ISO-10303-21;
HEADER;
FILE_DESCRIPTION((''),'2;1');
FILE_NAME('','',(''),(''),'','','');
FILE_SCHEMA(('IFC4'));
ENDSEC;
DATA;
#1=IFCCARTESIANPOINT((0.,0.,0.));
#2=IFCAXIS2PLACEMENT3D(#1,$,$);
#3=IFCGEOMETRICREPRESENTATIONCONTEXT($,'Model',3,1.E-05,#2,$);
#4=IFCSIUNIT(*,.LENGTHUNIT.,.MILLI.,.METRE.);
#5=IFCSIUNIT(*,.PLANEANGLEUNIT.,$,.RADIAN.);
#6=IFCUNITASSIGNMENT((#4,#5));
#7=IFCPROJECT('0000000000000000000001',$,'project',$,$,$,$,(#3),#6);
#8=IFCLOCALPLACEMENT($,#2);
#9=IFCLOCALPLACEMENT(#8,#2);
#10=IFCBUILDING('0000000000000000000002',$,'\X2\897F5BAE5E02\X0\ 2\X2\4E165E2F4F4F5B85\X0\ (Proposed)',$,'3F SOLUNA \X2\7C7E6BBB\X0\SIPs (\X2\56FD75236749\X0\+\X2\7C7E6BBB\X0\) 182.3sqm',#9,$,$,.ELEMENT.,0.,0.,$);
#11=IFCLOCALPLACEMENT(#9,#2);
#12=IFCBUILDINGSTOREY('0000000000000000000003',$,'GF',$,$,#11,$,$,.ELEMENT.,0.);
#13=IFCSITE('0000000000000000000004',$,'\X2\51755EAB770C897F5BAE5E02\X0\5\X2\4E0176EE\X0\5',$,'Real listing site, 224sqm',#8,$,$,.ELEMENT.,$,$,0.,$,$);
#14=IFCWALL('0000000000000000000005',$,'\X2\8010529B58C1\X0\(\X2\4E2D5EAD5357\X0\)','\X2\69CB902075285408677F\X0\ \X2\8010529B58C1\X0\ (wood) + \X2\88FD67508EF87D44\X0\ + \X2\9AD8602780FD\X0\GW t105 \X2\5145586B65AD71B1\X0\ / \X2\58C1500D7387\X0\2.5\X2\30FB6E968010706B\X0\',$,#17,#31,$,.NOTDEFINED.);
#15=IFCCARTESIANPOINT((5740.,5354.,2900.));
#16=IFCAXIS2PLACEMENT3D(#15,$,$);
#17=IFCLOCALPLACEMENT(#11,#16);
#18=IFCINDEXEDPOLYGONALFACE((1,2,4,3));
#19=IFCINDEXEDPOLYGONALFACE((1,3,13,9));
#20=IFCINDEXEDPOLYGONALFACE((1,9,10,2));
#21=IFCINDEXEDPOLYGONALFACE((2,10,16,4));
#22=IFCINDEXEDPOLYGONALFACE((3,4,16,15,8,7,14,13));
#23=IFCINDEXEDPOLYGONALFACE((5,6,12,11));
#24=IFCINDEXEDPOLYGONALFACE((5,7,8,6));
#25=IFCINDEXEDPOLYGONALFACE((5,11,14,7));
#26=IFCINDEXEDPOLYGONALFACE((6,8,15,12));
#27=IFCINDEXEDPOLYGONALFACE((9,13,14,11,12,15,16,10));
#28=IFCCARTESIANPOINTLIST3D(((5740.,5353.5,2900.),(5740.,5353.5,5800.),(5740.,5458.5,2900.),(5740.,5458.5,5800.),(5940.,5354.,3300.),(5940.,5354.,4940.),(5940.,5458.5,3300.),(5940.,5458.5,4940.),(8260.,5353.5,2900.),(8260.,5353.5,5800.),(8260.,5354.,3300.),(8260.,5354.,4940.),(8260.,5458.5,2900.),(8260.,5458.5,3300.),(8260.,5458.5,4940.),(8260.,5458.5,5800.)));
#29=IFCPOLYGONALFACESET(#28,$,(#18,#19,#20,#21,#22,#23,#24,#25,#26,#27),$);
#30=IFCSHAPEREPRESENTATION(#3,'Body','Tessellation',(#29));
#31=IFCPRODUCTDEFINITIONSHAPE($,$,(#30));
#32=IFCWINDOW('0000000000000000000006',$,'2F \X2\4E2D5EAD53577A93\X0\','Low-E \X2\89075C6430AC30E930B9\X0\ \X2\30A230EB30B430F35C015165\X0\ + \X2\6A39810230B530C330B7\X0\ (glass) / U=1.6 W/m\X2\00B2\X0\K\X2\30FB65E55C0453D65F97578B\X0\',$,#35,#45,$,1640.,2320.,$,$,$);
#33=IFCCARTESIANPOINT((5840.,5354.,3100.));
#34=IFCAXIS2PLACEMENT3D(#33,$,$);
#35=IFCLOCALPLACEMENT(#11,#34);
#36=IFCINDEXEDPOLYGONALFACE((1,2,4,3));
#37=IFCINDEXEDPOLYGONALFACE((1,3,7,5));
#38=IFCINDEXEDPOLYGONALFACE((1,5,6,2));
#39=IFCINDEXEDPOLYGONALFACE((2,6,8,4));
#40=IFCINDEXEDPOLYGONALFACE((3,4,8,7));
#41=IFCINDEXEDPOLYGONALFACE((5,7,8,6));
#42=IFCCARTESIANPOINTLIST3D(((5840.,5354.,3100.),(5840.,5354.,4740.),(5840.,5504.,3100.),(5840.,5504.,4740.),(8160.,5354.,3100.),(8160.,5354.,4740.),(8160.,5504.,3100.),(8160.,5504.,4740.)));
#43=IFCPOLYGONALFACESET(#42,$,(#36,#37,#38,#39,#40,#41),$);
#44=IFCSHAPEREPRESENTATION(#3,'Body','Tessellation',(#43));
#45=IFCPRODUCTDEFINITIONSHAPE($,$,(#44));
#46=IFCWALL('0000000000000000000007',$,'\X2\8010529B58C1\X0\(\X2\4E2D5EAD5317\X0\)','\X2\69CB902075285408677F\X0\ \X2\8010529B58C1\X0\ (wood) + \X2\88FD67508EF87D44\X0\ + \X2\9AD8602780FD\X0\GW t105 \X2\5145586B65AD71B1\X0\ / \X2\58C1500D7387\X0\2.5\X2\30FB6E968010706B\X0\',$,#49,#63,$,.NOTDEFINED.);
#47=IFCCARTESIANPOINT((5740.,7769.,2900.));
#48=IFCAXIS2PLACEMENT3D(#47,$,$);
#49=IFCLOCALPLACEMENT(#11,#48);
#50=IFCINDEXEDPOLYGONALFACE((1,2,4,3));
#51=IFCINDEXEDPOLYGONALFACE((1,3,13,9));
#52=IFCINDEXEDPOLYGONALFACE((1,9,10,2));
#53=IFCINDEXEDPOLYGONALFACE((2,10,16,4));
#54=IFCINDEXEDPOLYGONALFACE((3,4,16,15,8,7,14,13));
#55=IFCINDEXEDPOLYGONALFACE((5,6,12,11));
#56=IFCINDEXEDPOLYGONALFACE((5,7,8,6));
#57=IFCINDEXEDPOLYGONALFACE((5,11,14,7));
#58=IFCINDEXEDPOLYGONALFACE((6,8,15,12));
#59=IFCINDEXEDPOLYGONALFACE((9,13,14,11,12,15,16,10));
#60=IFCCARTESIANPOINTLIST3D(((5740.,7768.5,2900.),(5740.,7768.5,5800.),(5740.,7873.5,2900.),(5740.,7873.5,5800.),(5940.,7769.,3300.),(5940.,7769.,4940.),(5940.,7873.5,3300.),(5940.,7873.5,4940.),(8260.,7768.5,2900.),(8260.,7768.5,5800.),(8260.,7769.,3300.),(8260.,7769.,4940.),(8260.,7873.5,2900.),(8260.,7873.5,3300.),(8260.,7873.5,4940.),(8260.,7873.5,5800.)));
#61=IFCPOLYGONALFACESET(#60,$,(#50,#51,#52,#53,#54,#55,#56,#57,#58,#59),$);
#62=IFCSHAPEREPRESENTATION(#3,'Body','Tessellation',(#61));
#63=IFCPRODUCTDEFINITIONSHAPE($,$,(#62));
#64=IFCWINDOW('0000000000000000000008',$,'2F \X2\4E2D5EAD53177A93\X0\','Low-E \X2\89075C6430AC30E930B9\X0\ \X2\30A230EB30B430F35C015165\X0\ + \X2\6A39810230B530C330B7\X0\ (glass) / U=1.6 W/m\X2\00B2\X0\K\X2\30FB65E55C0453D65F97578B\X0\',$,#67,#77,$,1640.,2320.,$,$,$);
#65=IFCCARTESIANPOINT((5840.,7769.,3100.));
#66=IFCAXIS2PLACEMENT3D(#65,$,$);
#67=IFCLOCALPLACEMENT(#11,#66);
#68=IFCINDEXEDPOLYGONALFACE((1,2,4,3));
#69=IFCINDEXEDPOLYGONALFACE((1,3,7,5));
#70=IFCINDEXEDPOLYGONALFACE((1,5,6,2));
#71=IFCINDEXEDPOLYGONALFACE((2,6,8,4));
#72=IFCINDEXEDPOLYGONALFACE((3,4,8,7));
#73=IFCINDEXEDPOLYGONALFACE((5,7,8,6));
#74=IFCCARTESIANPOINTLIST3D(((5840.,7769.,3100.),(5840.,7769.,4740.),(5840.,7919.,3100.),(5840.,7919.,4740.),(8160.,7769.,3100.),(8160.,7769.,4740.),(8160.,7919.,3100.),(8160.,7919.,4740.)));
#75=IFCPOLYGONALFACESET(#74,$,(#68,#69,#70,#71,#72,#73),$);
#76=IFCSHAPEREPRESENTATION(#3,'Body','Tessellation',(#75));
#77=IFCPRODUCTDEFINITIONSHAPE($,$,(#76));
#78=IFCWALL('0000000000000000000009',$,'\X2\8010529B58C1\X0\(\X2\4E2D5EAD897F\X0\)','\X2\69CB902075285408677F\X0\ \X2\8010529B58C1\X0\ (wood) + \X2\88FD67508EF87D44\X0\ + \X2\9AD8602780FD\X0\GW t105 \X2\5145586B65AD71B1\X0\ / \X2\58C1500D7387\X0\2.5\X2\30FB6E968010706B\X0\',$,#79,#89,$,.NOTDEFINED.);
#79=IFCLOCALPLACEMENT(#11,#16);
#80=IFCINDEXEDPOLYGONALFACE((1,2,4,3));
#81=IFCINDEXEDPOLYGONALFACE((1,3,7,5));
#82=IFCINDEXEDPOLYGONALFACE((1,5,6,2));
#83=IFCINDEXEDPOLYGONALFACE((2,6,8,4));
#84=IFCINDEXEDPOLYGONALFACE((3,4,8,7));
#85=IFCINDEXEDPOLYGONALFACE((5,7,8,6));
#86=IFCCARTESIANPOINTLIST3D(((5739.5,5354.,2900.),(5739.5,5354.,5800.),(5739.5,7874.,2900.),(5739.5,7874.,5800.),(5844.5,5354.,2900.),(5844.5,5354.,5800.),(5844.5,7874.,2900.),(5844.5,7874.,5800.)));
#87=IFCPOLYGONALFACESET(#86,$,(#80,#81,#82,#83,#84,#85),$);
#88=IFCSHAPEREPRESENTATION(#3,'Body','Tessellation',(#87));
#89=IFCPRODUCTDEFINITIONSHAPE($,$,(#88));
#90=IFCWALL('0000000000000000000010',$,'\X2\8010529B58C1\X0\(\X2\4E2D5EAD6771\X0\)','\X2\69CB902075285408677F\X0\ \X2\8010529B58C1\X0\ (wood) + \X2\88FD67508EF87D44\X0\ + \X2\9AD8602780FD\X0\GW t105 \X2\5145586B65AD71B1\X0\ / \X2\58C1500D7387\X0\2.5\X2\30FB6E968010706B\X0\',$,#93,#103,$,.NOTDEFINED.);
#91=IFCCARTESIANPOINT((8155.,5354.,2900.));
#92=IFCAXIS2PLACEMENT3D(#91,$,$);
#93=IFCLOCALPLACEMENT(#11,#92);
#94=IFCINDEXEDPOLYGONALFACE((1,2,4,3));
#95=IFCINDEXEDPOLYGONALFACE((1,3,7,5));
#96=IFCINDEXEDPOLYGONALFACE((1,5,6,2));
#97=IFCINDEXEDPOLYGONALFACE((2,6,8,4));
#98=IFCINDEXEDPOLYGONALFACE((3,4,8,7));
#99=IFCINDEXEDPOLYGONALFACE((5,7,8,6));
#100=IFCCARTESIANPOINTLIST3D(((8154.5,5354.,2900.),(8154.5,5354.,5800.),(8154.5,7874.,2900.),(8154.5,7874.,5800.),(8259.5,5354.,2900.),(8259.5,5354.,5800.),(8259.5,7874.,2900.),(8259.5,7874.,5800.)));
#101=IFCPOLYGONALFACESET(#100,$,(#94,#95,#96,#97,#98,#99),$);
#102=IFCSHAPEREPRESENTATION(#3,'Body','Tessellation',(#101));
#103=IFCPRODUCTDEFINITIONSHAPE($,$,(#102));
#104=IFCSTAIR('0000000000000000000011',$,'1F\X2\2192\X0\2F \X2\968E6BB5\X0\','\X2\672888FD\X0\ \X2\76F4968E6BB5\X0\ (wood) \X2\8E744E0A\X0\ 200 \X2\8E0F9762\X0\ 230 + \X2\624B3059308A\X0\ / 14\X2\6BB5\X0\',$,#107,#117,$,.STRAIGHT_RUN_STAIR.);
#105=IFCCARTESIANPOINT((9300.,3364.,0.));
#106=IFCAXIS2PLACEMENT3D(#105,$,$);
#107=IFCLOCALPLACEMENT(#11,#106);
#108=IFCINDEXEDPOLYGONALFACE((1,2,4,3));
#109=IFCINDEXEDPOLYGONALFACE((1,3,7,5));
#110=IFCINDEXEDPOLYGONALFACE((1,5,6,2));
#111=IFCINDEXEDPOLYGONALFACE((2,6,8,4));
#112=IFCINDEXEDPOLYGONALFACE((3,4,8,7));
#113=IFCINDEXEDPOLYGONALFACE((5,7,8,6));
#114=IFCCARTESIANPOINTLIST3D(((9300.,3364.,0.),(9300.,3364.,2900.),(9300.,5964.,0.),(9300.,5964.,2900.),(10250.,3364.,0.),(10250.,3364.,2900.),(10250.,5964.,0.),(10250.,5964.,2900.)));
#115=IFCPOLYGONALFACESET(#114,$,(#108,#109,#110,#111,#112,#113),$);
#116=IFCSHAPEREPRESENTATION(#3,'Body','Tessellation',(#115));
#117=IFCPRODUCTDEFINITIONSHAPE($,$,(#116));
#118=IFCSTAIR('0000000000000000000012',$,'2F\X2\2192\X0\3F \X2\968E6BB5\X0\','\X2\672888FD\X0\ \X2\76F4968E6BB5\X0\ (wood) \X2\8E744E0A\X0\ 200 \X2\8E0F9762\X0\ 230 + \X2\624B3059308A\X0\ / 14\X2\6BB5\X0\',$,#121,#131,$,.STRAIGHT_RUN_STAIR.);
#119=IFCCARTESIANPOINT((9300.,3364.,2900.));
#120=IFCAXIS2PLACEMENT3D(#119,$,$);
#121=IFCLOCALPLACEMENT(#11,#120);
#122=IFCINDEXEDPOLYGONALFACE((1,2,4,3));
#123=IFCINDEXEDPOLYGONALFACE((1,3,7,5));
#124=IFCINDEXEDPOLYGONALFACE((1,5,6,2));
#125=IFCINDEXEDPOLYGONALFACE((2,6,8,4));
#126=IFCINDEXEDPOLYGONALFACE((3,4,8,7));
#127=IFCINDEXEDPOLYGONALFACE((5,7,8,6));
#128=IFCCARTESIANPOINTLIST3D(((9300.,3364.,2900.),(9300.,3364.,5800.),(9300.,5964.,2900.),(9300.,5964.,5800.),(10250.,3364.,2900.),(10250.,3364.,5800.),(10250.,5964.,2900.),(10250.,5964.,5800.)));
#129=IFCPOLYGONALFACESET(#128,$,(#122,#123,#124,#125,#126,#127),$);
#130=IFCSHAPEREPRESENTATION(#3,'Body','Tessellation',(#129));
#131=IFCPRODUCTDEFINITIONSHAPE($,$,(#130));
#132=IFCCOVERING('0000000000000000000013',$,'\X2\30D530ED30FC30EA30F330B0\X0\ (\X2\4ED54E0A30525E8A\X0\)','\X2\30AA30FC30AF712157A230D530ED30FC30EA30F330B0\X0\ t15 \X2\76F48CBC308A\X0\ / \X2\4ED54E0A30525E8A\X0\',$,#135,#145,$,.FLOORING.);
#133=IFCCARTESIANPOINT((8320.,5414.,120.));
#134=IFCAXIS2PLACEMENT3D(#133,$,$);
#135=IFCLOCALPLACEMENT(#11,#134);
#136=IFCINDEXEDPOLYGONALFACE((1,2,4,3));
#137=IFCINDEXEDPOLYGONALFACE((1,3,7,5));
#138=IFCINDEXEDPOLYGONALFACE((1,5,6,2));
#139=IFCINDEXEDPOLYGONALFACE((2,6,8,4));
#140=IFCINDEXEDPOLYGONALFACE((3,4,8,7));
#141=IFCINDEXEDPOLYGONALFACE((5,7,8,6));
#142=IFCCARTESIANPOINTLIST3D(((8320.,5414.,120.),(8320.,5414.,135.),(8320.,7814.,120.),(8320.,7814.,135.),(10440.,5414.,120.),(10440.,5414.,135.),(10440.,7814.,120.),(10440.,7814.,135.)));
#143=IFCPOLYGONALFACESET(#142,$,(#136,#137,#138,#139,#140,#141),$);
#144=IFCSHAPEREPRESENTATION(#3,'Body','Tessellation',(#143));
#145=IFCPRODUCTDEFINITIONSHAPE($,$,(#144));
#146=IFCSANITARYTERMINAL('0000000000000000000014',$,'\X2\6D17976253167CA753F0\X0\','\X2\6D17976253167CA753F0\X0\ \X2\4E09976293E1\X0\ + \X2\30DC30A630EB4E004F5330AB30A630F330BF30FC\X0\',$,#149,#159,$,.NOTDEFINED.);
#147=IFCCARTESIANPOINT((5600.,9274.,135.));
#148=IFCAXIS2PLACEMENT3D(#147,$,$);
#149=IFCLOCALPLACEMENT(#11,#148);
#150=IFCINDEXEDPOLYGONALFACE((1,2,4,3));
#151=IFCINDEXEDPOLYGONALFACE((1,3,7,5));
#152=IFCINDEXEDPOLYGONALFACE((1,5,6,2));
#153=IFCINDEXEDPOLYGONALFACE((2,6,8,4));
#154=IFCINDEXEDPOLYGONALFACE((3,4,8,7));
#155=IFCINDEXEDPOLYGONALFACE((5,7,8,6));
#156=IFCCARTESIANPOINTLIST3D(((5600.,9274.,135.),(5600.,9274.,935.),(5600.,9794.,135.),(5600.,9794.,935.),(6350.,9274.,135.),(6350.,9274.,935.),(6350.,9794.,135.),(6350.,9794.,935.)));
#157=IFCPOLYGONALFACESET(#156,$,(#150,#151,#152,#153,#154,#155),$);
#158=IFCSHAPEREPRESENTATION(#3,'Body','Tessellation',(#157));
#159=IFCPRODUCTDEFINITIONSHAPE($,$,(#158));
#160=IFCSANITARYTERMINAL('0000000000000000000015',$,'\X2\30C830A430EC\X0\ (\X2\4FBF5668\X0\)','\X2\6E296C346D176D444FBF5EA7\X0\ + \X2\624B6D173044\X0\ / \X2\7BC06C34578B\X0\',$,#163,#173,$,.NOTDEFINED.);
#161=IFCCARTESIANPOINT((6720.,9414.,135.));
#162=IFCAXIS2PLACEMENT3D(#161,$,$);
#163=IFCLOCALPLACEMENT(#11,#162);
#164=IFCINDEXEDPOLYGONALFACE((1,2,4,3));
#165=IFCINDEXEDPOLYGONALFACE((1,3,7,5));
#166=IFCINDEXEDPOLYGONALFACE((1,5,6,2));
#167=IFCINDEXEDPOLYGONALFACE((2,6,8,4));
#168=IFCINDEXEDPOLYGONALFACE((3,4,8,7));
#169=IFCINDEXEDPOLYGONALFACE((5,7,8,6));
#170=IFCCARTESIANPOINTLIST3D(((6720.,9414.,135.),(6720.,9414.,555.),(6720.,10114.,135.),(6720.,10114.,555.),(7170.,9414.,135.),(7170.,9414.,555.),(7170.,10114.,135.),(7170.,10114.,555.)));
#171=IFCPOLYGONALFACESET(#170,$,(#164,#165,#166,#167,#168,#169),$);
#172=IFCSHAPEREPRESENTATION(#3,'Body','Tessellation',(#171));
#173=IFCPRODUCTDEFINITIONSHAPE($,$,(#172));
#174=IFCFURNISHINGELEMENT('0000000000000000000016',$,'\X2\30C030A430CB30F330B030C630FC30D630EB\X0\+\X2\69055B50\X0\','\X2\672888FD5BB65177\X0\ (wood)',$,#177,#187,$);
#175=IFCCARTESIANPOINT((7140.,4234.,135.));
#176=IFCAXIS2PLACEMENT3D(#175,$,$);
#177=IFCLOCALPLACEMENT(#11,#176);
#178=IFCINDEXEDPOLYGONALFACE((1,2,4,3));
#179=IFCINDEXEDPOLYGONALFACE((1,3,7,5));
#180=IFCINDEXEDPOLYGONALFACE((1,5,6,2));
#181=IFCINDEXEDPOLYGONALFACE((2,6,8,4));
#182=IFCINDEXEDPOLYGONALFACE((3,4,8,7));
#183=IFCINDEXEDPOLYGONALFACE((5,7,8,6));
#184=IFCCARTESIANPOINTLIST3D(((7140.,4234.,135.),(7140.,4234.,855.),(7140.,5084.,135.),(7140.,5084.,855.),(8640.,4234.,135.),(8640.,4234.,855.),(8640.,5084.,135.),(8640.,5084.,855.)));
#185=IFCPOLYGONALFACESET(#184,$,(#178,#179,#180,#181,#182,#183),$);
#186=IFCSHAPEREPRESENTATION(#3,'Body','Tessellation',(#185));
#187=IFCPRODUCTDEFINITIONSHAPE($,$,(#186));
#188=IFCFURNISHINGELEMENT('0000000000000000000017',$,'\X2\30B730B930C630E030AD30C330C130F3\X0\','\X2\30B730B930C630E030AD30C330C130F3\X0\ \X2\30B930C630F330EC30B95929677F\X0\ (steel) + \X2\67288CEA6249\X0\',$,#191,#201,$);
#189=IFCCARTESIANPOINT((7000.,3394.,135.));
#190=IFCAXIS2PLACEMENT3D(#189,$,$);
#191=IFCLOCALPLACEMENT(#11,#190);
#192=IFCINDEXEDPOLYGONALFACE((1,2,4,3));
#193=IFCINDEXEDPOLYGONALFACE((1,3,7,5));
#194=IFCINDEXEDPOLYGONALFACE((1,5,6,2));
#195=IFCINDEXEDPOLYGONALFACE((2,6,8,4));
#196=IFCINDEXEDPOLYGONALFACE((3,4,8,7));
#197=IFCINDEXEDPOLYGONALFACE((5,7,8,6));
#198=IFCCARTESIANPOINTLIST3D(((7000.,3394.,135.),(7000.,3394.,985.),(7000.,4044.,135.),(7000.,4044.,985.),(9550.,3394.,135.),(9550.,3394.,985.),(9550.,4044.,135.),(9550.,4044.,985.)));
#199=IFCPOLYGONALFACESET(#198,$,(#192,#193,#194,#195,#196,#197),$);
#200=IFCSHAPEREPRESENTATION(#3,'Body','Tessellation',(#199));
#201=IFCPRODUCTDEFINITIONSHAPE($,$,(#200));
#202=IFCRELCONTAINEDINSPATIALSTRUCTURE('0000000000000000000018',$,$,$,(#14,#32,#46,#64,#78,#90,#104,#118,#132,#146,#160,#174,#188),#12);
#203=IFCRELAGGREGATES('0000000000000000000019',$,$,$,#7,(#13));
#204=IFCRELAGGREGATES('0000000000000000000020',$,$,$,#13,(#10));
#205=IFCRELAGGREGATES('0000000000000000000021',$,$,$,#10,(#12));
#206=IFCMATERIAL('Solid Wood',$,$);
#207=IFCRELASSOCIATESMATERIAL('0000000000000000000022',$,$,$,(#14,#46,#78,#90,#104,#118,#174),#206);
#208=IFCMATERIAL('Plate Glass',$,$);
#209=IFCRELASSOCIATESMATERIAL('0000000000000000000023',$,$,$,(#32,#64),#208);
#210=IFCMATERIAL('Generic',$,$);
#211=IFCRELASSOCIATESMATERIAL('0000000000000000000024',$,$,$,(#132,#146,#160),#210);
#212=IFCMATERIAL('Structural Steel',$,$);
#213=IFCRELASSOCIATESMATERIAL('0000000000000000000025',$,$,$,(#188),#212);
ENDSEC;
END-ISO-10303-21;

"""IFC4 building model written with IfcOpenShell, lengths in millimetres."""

from ifc_helpers import new_model, si_unit, frame, frame_2d, origin, place, context, project, spatial, rectangle, extrude, material, element, fill, save


model = new_model("IFC4")

# Units and contexts
model_context = context("Model", 3, precision=1e-05, world=origin())
ifc_project = project(units=[si_unit("LENGTHUNIT", "METRE", prefix="MILLI"), si_unit("PLANEANGLEUNIT", "RADIAN")], contexts=[model_context])

# Site, building, storey
site_placement = place(None, origin())
site = spatial("IfcSite", under=ifc_project, at=site_placement, Name="兵庫県西宮市5丁目5", ObjectType="Real listing site, 224sqm", CompositionType="ELEMENT", RefElevation=0.0)
building_placement = place(site_placement, origin())
building = spatial("IfcBuilding", under=site, at=building_placement, Name="西宮市 2世帯住宅 (Proposed)", ObjectType="3F SOLUNA 籾殻SIPs (国産杉+籾殻) 182.3sqm", CompositionType="ELEMENT", ElevationOfRefHeight=0.0, ElevationOfTerrain=0.0)
storey_placement = place(building_placement, origin())
storey = spatial("IfcBuildingStorey", under=building, at=storey_placement, Name="GF", CompositionType="ELEMENT", Elevation=0.0)

# Shared definitions
ifc_material_1 = material(Name="Solid Wood")

# Shared definitions
ifc_material_2 = material(Name="Plate Glass")

# Walls, openings, windows
wall_1_placement = place(storey_placement, frame((5740.0, 5354.0, 2900.0)))
wall_1 = element("IfcWall", 1, at=wall_1_placement, inside=storey, material=ifc_material_1, Name="耐力壁(中庭南)", Description="構造用合板 耐力壁 (wood) + 製材軸組 + 高性能GW t105 充填断熱 / 壁倍率2.5・準耐火", PredefinedType="NOTDEFINED", context=model_context, shape_type="SweptSolid", body=[
    extrude(rectangle(XDim=2520.0, YDim=105.0, at=frame_2d((1260.0, 52.0))), frame((5740.0, 5354.0, 2900.0)), (0.0, 0.0, 1.0), 2900.0),
])
opening_1_placement = place(storey_placement, frame((5840.0, 5354.0, 3100.0)))
opening_1 = element("IfcOpeningElement", 2, at=opening_1_placement, cuts=wall_1, PredefinedType="NOTDEFINED", context=model_context, shape_type="SweptSolid", body=[
    extrude(rectangle(XDim=2320.0, YDim=150.0, at=frame_2d((1160.0, 75.0))), frame((5840.0, 5354.0, 3100.0)), (0.0, 0.0, 1.0), 1640.0),
])
window_1_placement = place(storey_placement, frame((5840.0, 5354.0, 3100.0)))
window_1 = element("IfcWindow", 3, at=window_1_placement, inside=storey, material=ifc_material_2, Name="2F 中庭南窓", Description="Low-E 複層ガラス アルゴン封入 + 樹脂サッシ (glass) / U=1.6 W/m²K・日射取得型", OverallHeight=1640.0, OverallWidth=2320.0, context=model_context, shape_type="SweptSolid", body=[
    extrude(rectangle(XDim=2320.0, YDim=150.0, at=frame_2d((1160.0, 75.0))), frame((5840.0, 5354.0, 3100.0)), (0.0, 0.0, 1.0), 1640.0),
])
fill(opening_1, window_1)
wall_2_placement = place(storey_placement, frame((5740.0, 7769.0, 2900.0)))
wall_2 = element("IfcWall", 4, at=wall_2_placement, inside=storey, material=ifc_material_1, Name="耐力壁(中庭北)", Description="構造用合板 耐力壁 (wood) + 製材軸組 + 高性能GW t105 充填断熱 / 壁倍率2.5・準耐火", PredefinedType="NOTDEFINED", context=model_context, shape_type="SweptSolid", body=[
    extrude(rectangle(XDim=2520.0, YDim=105.0, at=frame_2d((1260.0, 52.0))), frame((5740.0, 7769.0, 2900.0)), (0.0, 0.0, 1.0), 2900.0),
])
opening_2_placement = place(storey_placement, frame((5840.0, 7769.0, 3100.0)))
opening_2 = element("IfcOpeningElement", 5, at=opening_2_placement, cuts=wall_2, PredefinedType="NOTDEFINED", context=model_context, shape_type="SweptSolid", body=[
    extrude(rectangle(XDim=2320.0, YDim=150.0, at=frame_2d((1160.0, 75.0))), frame((5840.0, 7769.0, 3100.0)), (0.0, 0.0, 1.0), 1640.0),
])
window_2_placement = place(storey_placement, frame((5840.0, 7769.0, 3100.0)))
window_2 = element("IfcWindow", 6, at=window_2_placement, inside=storey, material=ifc_material_2, Name="2F 中庭北窓", Description="Low-E 複層ガラス アルゴン封入 + 樹脂サッシ (glass) / U=1.6 W/m²K・日射取得型", OverallHeight=1640.0, OverallWidth=2320.0, context=model_context, shape_type="SweptSolid", body=[
    extrude(rectangle(XDim=2320.0, YDim=150.0, at=frame_2d((1160.0, 75.0))), frame((5840.0, 7769.0, 3100.0)), (0.0, 0.0, 1.0), 1640.0),
])
fill(opening_2, window_2)

# Walls
wall_3_placement = place(storey_placement, frame((5740.0, 5354.0, 2900.0)))
element("IfcWall", 7, at=wall_3_placement, inside=storey, material=ifc_material_1, Name="耐力壁(中庭西)", Description="構造用合板 耐力壁 (wood) + 製材軸組 + 高性能GW t105 充填断熱 / 壁倍率2.5・準耐火", PredefinedType="NOTDEFINED", context=model_context, shape_type="SweptSolid", body=[
    extrude(rectangle(XDim=105.0, YDim=2520.0, at=frame_2d((52.0, 1260.0))), frame((5740.0, 5354.0, 2900.0)), (0.0, 0.0, 1.0), 2900.0),
])
wall_4_placement = place(storey_placement, frame((8155.0, 5354.0, 2900.0)))
element("IfcWall", 8, at=wall_4_placement, inside=storey, material=ifc_material_1, Name="耐力壁(中庭東)", Description="構造用合板 耐力壁 (wood) + 製材軸組 + 高性能GW t105 充填断熱 / 壁倍率2.5・準耐火", PredefinedType="NOTDEFINED", context=model_context, shape_type="SweptSolid", body=[
    extrude(rectangle(XDim=105.0, YDim=2520.0, at=frame_2d((52.0, 1260.0))), frame((8155.0, 5354.0, 2900.0)), (0.0, 0.0, 1.0), 2900.0),
])

# Stairs
stair_1_placement = place(storey_placement, frame((9300.0, 3364.0, 0.0)))
element("IfcStair", 9, at=stair_1_placement, inside=storey, material=ifc_material_1, Name="1F→2F 階段", Description="木製 直階段 (wood) 蹴上 200 踏面 230 + 手すり / 14段", PredefinedType="STRAIGHT_RUN_STAIR", context=model_context, shape_type="SweptSolid", body=[
    extrude(rectangle(XDim=950.0, YDim=2600.0, at=frame_2d((475.0, 1300.0))), frame((9300.0, 3364.0, 0.0)), (0.0, 0.0, 1.0), 2900.0),
])
stair_2_placement = place(storey_placement, frame((9300.0, 3364.0, 2900.0)))
element("IfcStair", 10, at=stair_2_placement, inside=storey, material=ifc_material_1, Name="2F→3F 階段", Description="木製 直階段 (wood) 蹴上 200 踏面 230 + 手すり / 14段", PredefinedType="STRAIGHT_RUN_STAIR", context=model_context, shape_type="SweptSolid", body=[
    extrude(rectangle(XDim=950.0, YDim=2600.0, at=frame_2d((475.0, 1300.0))), frame((9300.0, 3364.0, 2900.0)), (0.0, 0.0, 1.0), 2900.0),
])

# Covering
ifc_material_3 = material(Name="Generic")
covering_placement = place(storey_placement, frame((8320.0, 5414.0, 120.0)))
element("IfcCovering", 11, at=covering_placement, inside=storey, material=ifc_material_3, Name="フローリング (仕上げ床)", Description="オーク無垢フローリング t15 直貼り / 仕上げ床", PredefinedType="FLOORING", context=model_context, shape_type="SweptSolid", body=[
    extrude(rectangle(XDim=2120.0, YDim=2400.0, at=frame_2d((1060.0, 1200.0))), frame((8320.0, 5414.0, 120.0)), (0.0, 0.0, 1.0), 15.0),
])

# Sanitary terminals
sanitary_terminal_1_placement = place(storey_placement, frame((5600.0, 9274.0, 135.0)))
element("IfcSanitaryTerminal", 12, at=sanitary_terminal_1_placement, inside=storey, material=ifc_material_3, Name="洗面化粧台", Description="洗面化粧台 三面鏡 + ボウル一体カウンター", PredefinedType="NOTDEFINED", context=model_context, shape_type="SweptSolid", body=[
    extrude(rectangle(XDim=750.0, YDim=520.0, at=frame_2d((375.0, 260.0))), frame((5600.0, 9274.0, 135.0)), (0.0, 0.0, 1.0), 800.0),
])
sanitary_terminal_2_placement = place(storey_placement, frame((6720.0, 9414.0, 135.0)))
element("IfcSanitaryTerminal", 13, at=sanitary_terminal_2_placement, inside=storey, material=ifc_material_3, Name="トイレ (便器)", Description="温水洗浄便座 + 手洗い / 節水型", PredefinedType="NOTDEFINED", context=model_context, shape_type="SweptSolid", body=[
    extrude(rectangle(XDim=450.0, YDim=700.0, at=frame_2d((225.0, 350.0))), frame((6720.0, 9414.0, 135.0)), (0.0, 0.0, 1.0), 420.0),
])

# Furnishing elements
furnishing_1_placement = place(storey_placement, frame((7140.0, 4234.0, 135.0)))
element("IfcFurnishingElement", 14, at=furnishing_1_placement, inside=storey, material=ifc_material_1, Name="ダイニングテーブル+椅子", Description="木製家具 (wood)", context=model_context, shape_type="SweptSolid", body=[
    extrude(rectangle(XDim=1500.0, YDim=850.0, at=frame_2d((750.0, 425.0))), frame((7140.0, 4234.0, 135.0)), (0.0, 0.0, 1.0), 720.0),
])
ifc_material_4 = material(Name="Structural Steel")
furnishing_2_placement = place(storey_placement, frame((7000.0, 3394.0, 135.0)))
element("IfcFurnishingElement", 15, at=furnishing_2_placement, inside=storey, material=ifc_material_4, Name="システムキッチン", Description="システムキッチン ステンレス天板 (steel) + 木質扉", context=model_context, shape_type="SweptSolid", body=[
    extrude(rectangle(XDim=2550.0, YDim=650.0, at=frame_2d((1275.0, 325.0))), frame((7000.0, 3394.0, 135.0)), (0.0, 0.0, 1.0), 850.0),
])

save(model, "model.ifc")
